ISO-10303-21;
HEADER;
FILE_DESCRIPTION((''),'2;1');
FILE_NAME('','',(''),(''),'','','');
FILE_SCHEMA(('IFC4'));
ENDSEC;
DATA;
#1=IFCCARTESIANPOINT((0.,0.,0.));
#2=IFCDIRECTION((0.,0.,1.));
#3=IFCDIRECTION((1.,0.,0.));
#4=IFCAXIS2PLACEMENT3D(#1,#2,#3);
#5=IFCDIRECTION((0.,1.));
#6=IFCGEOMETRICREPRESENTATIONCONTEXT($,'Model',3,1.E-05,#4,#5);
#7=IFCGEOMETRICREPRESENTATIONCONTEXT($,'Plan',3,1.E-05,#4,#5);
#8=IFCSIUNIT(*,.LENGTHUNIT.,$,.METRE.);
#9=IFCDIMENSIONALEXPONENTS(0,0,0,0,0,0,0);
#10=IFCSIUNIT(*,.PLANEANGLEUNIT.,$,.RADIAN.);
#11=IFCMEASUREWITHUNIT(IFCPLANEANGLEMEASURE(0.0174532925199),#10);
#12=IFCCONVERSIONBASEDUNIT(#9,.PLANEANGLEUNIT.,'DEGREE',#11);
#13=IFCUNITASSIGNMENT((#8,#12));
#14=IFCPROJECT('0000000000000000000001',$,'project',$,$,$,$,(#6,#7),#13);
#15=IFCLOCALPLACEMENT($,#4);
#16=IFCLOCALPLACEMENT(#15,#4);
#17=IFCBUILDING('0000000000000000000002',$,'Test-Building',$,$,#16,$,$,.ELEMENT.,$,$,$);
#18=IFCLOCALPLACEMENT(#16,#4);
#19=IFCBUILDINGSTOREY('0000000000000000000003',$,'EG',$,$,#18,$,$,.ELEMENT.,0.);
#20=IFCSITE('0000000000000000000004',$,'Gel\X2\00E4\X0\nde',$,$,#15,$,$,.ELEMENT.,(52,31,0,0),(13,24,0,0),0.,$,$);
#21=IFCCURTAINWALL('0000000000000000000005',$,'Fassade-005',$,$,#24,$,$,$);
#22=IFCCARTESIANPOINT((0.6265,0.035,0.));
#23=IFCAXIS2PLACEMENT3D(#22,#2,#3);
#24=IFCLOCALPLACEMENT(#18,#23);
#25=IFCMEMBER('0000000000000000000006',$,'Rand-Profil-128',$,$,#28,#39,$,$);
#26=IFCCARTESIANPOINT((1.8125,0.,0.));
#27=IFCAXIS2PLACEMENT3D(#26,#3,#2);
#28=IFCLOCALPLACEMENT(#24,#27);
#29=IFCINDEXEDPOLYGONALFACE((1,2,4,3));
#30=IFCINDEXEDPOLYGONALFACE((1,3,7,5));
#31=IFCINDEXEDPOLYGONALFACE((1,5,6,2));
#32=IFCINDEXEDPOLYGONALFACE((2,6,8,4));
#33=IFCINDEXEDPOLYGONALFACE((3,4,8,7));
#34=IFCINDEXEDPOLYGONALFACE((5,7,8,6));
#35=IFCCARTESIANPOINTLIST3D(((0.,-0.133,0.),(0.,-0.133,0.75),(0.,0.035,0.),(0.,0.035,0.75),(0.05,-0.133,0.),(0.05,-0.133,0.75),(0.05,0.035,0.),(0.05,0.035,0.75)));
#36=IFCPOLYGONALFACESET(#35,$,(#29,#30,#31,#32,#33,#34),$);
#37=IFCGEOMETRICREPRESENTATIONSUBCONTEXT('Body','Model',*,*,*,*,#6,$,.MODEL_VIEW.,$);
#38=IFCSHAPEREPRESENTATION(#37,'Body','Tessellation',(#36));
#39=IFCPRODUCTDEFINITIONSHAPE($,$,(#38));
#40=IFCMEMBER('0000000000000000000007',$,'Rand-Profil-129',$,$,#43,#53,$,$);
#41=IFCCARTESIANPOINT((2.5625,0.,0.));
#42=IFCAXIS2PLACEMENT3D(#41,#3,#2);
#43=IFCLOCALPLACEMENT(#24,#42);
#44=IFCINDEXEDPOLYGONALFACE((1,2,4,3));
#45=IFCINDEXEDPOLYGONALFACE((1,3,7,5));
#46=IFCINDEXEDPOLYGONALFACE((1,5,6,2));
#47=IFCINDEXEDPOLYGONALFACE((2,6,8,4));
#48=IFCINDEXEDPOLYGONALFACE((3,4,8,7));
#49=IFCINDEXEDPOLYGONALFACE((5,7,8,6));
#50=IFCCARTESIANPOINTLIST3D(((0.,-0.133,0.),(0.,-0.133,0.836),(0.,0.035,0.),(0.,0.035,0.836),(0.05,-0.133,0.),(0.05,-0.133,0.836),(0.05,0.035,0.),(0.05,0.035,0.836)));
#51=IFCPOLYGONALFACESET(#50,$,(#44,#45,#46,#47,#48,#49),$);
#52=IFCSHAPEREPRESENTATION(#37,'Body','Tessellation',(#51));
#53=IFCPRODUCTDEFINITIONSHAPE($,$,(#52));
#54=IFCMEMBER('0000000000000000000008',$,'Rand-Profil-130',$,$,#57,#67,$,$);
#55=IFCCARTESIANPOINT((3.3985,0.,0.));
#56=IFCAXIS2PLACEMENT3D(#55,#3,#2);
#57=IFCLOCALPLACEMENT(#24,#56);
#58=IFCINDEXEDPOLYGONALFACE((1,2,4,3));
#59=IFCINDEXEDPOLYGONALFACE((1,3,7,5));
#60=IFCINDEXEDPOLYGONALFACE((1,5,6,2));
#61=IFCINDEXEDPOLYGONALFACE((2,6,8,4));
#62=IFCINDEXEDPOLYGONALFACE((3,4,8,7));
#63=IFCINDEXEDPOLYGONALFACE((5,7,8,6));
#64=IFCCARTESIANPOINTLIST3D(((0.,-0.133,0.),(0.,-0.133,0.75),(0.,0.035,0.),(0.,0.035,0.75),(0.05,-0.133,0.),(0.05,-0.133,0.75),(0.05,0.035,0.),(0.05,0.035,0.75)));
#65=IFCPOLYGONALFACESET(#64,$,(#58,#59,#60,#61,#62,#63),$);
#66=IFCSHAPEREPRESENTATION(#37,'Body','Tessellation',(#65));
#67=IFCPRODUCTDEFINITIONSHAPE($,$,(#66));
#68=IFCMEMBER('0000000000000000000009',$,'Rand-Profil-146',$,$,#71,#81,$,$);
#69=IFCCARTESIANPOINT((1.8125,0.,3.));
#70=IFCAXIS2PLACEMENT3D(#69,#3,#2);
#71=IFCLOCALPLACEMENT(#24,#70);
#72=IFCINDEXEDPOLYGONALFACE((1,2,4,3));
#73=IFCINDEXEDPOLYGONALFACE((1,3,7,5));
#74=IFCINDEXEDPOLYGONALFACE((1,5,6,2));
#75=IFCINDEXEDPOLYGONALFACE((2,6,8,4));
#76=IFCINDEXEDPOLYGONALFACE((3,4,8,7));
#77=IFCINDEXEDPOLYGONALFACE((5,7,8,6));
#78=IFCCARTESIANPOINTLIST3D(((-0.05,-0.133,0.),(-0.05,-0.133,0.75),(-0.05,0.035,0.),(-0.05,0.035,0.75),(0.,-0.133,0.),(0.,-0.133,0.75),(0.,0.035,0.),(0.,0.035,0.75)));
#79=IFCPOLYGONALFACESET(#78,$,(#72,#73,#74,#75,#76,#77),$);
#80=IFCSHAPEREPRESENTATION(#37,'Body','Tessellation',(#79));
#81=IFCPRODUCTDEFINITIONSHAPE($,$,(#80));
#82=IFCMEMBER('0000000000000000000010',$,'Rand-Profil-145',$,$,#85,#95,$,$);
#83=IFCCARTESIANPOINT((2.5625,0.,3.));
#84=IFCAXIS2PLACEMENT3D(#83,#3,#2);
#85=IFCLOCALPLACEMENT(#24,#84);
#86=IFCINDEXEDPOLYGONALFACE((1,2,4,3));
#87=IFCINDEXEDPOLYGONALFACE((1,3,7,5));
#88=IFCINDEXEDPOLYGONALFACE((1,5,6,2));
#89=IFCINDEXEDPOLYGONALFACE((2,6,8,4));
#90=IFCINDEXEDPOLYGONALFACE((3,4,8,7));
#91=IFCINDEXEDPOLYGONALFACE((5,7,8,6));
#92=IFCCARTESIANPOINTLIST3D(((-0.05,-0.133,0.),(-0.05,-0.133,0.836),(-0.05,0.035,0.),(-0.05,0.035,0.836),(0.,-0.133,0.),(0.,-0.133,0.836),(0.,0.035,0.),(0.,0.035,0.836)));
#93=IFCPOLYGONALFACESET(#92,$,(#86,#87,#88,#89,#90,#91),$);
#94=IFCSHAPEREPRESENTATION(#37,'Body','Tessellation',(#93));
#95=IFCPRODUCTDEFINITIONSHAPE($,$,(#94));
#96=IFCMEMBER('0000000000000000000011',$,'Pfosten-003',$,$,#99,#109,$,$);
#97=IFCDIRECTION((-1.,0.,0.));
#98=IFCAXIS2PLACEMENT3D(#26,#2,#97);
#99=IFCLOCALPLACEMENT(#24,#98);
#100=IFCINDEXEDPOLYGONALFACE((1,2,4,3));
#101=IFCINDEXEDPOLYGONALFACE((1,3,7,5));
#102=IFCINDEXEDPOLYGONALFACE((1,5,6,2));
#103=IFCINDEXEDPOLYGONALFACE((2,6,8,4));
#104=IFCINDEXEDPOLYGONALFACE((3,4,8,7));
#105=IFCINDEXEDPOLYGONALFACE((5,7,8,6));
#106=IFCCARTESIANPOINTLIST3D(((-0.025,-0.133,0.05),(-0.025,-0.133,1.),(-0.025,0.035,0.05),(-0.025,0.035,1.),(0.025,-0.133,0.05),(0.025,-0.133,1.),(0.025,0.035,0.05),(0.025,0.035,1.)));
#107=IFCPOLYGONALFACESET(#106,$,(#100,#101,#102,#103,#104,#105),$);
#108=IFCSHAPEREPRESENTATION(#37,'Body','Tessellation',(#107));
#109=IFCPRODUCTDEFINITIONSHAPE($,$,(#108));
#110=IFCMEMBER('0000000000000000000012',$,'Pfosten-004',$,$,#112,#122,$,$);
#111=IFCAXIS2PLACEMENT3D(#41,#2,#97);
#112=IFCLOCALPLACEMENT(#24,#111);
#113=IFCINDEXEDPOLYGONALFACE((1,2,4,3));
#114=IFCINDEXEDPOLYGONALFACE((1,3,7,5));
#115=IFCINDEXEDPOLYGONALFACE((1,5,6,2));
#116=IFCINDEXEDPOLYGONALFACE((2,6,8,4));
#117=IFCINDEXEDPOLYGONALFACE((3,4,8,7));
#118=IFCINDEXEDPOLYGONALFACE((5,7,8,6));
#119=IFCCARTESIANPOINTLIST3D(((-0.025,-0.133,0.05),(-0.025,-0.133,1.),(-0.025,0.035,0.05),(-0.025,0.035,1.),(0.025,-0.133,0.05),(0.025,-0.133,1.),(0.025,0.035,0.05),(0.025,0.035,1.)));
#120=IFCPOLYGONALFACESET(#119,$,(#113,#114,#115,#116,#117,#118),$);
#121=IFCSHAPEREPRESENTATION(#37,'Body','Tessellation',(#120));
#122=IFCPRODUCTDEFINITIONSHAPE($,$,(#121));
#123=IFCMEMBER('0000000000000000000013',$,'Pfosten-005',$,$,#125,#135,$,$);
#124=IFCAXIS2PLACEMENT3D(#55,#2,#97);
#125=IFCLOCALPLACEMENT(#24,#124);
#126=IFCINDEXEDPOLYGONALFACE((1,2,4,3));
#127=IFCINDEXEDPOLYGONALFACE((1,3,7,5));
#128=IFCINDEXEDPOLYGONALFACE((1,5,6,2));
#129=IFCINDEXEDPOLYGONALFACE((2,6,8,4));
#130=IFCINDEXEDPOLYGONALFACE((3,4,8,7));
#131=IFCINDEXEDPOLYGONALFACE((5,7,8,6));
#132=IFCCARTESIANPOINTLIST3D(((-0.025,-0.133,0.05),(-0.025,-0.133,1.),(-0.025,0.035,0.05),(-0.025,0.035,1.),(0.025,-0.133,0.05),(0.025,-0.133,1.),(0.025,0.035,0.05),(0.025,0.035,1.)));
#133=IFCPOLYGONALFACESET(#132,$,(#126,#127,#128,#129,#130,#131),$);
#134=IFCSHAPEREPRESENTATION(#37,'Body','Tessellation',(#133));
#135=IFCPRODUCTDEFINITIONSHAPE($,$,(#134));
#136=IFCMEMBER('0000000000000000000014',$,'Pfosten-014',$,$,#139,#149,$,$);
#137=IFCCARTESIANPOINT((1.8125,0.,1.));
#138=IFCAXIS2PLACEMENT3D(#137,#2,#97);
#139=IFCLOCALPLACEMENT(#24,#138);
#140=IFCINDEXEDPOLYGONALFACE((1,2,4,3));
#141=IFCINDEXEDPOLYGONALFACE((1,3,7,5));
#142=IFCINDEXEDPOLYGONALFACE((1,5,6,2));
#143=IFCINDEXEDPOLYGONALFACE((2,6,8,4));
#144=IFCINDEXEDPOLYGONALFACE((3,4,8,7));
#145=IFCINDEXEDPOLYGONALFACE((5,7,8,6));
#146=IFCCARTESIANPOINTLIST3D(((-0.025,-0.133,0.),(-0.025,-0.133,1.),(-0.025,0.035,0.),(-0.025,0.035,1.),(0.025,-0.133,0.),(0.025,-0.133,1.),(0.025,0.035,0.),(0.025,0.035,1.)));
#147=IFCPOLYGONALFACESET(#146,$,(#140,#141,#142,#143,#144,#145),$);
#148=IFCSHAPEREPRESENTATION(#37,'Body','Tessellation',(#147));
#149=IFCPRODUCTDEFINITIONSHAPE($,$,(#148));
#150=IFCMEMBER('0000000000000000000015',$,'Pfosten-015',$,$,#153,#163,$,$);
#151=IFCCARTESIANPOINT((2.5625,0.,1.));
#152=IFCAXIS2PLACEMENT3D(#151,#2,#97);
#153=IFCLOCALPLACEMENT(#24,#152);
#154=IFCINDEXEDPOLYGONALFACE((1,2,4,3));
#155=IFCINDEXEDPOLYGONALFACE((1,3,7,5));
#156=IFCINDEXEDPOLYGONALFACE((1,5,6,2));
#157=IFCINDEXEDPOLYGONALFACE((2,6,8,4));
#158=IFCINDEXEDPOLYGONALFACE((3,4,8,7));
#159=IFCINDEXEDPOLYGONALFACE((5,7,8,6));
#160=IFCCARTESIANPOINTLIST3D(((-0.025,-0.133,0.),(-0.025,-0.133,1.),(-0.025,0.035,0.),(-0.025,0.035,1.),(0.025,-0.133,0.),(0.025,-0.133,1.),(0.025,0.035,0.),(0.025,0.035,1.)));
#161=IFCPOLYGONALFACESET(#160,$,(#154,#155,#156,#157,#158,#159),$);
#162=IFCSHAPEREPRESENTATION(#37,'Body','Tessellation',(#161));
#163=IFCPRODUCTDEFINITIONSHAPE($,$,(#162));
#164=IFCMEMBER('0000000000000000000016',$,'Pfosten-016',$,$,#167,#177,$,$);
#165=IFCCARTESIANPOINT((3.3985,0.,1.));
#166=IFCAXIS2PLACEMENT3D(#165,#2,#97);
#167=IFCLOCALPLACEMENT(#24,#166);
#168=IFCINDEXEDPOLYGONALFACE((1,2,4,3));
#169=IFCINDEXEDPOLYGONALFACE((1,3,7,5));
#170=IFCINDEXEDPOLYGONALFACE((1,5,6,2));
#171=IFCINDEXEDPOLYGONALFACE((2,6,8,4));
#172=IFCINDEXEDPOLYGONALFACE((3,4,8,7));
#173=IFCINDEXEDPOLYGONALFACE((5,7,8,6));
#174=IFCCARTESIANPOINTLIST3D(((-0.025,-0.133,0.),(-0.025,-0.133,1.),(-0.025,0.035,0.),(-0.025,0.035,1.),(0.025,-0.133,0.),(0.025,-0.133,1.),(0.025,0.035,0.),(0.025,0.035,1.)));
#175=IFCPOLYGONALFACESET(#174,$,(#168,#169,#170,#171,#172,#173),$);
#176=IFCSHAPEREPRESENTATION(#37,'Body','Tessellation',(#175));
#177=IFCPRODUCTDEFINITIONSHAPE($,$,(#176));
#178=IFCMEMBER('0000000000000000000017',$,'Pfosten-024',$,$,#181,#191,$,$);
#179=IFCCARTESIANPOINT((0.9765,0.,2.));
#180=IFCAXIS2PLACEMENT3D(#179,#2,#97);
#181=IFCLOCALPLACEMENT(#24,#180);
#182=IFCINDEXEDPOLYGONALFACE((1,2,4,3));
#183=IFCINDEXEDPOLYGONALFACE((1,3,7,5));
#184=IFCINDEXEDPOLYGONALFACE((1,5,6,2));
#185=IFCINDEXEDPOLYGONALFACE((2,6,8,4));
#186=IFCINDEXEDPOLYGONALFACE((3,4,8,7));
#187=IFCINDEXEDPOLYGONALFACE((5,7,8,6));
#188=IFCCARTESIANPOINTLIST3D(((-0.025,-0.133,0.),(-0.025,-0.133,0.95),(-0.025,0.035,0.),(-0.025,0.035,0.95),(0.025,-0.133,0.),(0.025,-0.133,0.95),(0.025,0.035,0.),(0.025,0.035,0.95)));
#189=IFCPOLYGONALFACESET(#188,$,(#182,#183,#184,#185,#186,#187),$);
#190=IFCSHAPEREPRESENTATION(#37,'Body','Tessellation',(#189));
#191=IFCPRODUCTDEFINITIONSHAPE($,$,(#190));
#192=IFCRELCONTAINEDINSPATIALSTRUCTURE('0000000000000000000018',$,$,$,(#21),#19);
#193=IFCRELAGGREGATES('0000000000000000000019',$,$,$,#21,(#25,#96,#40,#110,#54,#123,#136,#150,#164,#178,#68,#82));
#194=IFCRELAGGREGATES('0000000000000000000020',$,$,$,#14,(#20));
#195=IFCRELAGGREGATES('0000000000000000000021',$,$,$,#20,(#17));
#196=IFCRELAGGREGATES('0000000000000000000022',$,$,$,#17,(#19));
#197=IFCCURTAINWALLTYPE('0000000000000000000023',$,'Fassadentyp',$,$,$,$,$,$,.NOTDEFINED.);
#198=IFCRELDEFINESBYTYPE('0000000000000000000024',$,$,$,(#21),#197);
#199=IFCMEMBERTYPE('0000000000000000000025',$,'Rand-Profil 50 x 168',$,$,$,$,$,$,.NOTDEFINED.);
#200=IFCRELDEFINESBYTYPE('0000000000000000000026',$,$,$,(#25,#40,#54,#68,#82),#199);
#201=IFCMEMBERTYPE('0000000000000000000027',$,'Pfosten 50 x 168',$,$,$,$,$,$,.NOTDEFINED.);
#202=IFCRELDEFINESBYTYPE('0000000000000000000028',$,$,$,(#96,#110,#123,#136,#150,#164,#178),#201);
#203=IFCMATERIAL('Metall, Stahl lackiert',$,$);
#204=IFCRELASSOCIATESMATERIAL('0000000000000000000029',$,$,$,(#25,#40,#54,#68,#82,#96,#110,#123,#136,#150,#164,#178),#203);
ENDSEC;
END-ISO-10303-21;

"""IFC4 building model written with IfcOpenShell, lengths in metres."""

from ifc_helpers import new_model, entity, si_unit, converted_unit, direction, frame, origin_with_axes, place, context, subcontext, project, spatial, polyline, outline, extrude, material, type_object, element, aggregate, save


model = new_model("IFC4")

# Units and contexts
model_context = context("Model", 3, precision=1e-05, world=origin_with_axes(), true_north=direction((0.0, 1.0)))
plan_context = context("Plan", 3, precision=1e-05, world=origin_with_axes(), true_north=direction((0.0, 1.0)))
body_context = subcontext(model_context, "Body", "Model", "MODEL_VIEW")
ifc_project = project(units=[si_unit("LENGTHUNIT", "METRE"), converted_unit("PLANEANGLEUNIT", "DEGREE", entity("IfcPlaneAngleMeasure", 0.0174532925199), si_unit("PLANEANGLEUNIT", "RADIAN"), dimensions=[0, 0, 0, 0, 0, 0, 0])], contexts=[model_context, plan_context])

# Site, building, storey
site_placement = place(None, origin_with_axes())
site = spatial("IfcSite", under=ifc_project, at=site_placement, Name="Gelände", CompositionType="ELEMENT", RefLatitude=(52, 31, 0, 0), RefLongitude=(13, 24, 0, 0), RefElevation=0.0)
building_placement = place(site_placement, origin_with_axes())
building = spatial("IfcBuilding", under=site, at=building_placement, Name="Test-Building", CompositionType="ELEMENT")
storey_placement = place(building_placement, origin_with_axes())
storey = spatial("IfcBuildingStorey", under=building, at=storey_placement, Name="EG", CompositionType="ELEMENT", Elevation=0.0)

# Curtain wall, members
curtain_wall_type = type_object("IfcCurtainWallType", Name="Fassadentyp", PredefinedType="NOTDEFINED")
curtain_wall_placement = place(storey_placement, frame((0.6265, 0.035, 0.0), z_axis=(0.0, 0.0, 1.0), x_axis=(1.0, 0.0, 0.0)))
curtain_wall = element("IfcCurtainWall", 1, at=curtain_wall_placement, inside=storey, type_object=curtain_wall_type, Name="Fassade-005")
ifc_material_1 = material(Name="Metall, Stahl lackiert")
member_type_1 = type_object("IfcMemberType", Name="Rand-Profil 50 x 168", PredefinedType="NOTDEFINED")
member_1_placement = place(curtain_wall_placement, frame((1.8125, 0.0, 0.0), z_axis=(1.0, 0.0, 0.0), x_axis=(0.0, 0.0, 1.0)))
member_1 = element("IfcMember", 2, at=member_1_placement, type_object=member_type_1, material=ifc_material_1, Name="Rand-Profil-128", context=body_context, shape_type="SweptSolid", body=[
    extrude(outline(polyline([(-0.133, -0.05), (0.035, -0.05), (0.035, 0.0), (-0.133, 0.0), (-0.133, -0.05)])), frame((0.0, 0.0, 0.0), z_axis=(0.0, 0.0, 1.0), x_axis=(0.0, 1.0, 0.0)), (0.0, 0.0, 1.0), 0.75),
])
member_2_placement = place(curtain_wall_placement, frame((2.5625, 0.0, 0.0), z_axis=(1.0, 0.0, 0.0), x_axis=(0.0, 0.0, 1.0)))
member_2 = element("IfcMember", 3, at=member_2_placement, type_object=member_type_1, material=ifc_material_1, Name="Rand-Profil-129", context=body_context, shape_type="SweptSolid", body=[
    extrude(outline(polyline([(-0.133, -0.05), (0.035, -0.05), (0.035, 0.0), (-0.133, 0.0), (-0.133, -0.05)])), frame((0.0, 0.0, 0.0), z_axis=(0.0, 0.0, 1.0), x_axis=(0.0, 1.0, 0.0)), (0.0, 0.0, 1.0), 0.836),
])
member_3_placement = place(curtain_wall_placement, frame((3.3985, 0.0, 0.0), z_axis=(1.0, 0.0, 0.0), x_axis=(0.0, 0.0, 1.0)))
member_3 = element("IfcMember", 4, at=member_3_placement, type_object=member_type_1, material=ifc_material_1, Name="Rand-Profil-130", context=body_context, shape_type="SweptSolid", body=[
    extrude(outline(polyline([(-0.133, -0.05), (0.035, -0.05), (0.035, 0.0), (-0.133, 0.0), (-0.133, -0.05)])), frame((0.0, 0.0, 0.0), z_axis=(0.0, 0.0, 1.0), x_axis=(0.0, 1.0, 0.0)), (0.0, 0.0, 1.0), 0.75),
])
member_4_placement = place(curtain_wall_placement, frame((1.8125, 0.0, 3.0), z_axis=(1.0, 0.0, 0.0), x_axis=(0.0, 0.0, 1.0)))
member_4 = element("IfcMember", 5, at=member_4_placement, type_object=member_type_1, material=ifc_material_1, Name="Rand-Profil-146", context=body_context, shape_type="SweptSolid", body=[
    extrude(outline(polyline([(-0.133, 0.05), (-0.133, 0.0), (0.035, 0.0), (0.035, 0.05), (-0.133, 0.05)])), frame((0.0, 0.0, 0.0), z_axis=(0.0, 0.0, 1.0), x_axis=(0.0, 1.0, 0.0)), (0.0, 0.0, 1.0), 0.75),
])
member_5_placement = place(curtain_wall_placement, frame((2.5625, 0.0, 3.0), z_axis=(1.0, 0.0, 0.0), x_axis=(0.0, 0.0, 1.0)))
member_5 = element("IfcMember", 6, at=member_5_placement, type_object=member_type_1, material=ifc_material_1, Name="Rand-Profil-145", context=body_context, shape_type="SweptSolid", body=[
    extrude(outline(polyline([(-0.133, 0.05), (-0.133, 0.0), (0.035, 0.0), (0.035, 0.05), (-0.133, 0.05)])), frame((0.0, 0.0, 0.0), z_axis=(0.0, 0.0, 1.0), x_axis=(0.0, 1.0, 0.0)), (0.0, 0.0, 1.0), 0.836),
])
member_type_2 = type_object("IfcMemberType", Name="Pfosten 50 x 168", PredefinedType="NOTDEFINED")
member_6_placement = place(curtain_wall_placement, frame((1.8125, 0.0, 0.0), z_axis=(0.0, 0.0, 1.0), x_axis=(-1.0, 0.0, 0.0)))
member_6 = element("IfcMember", 7, at=member_6_placement, type_object=member_type_2, material=ifc_material_1, Name="Pfosten-003", context=body_context, shape_type="SweptSolid", body=[
    extrude(outline(polyline([(-0.025, 0.133), (-0.025, -0.035), (0.025, -0.035), (0.025, 0.133), (-0.025, 0.133)])), frame((0.0, 0.0, 0.05), z_axis=(0.0, 0.0, 1.0), x_axis=(-1.0, 0.0, 0.0)), (0.0, 0.0, 1.0), 0.95),
])
member_7_placement = place(curtain_wall_placement, frame((2.5625, 0.0, 0.0), z_axis=(0.0, 0.0, 1.0), x_axis=(-1.0, 0.0, 0.0)))
member_7 = element("IfcMember", 8, at=member_7_placement, type_object=member_type_2, material=ifc_material_1, Name="Pfosten-004", context=body_context, shape_type="SweptSolid", body=[
    extrude(outline(polyline([(-0.025, 0.133), (-0.025, -0.035), (0.025, -0.035), (0.025, 0.133), (-0.025, 0.133)])), frame((0.0, 0.0, 0.05), z_axis=(0.0, 0.0, 1.0), x_axis=(-1.0, 0.0, 0.0)), (0.0, 0.0, 1.0), 0.95),
])
member_8_placement = place(curtain_wall_placement, frame((3.3985, 0.0, 0.0), z_axis=(0.0, 0.0, 1.0), x_axis=(-1.0, 0.0, 0.0)))
member_8 = element("IfcMember", 9, at=member_8_placement, type_object=member_type_2, material=ifc_material_1, Name="Pfosten-005", context=body_context, shape_type="SweptSolid", body=[
    extrude(outline(polyline([(-0.025, 0.133), (-0.025, -0.035), (0.025, -0.035), (0.025, 0.133), (-0.025, 0.133)])), frame((0.0, 0.0, 0.05), z_axis=(0.0, 0.0, 1.0), x_axis=(-1.0, 0.0, 0.0)), (0.0, 0.0, 1.0), 0.95),
])
member_9_placement = place(curtain_wall_placement, frame((1.8125, 0.0, 1.0), z_axis=(0.0, 0.0, 1.0), x_axis=(-1.0, 0.0, 0.0)))
member_9 = element("IfcMember", 10, at=member_9_placement, type_object=member_type_2, material=ifc_material_1, Name="Pfosten-014", context=body_context, shape_type="SweptSolid", body=[
    extrude(outline(polyline([(-0.025, 0.133), (-0.025, -0.035), (0.025, -0.035), (0.025, 0.133), (-0.025, 0.133)])), frame((0.0, 0.0, 0.0), z_axis=(0.0, 0.0, 1.0), x_axis=(-1.0, 0.0, 0.0)), (0.0, 0.0, 1.0), 1.0),
])
member_10_placement = place(curtain_wall_placement, frame((2.5625, 0.0, 1.0), z_axis=(0.0, 0.0, 1.0), x_axis=(-1.0, 0.0, 0.0)))
member_10 = element("IfcMember", 11, at=member_10_placement, type_object=member_type_2, material=ifc_material_1, Name="Pfosten-015", context=body_context, shape_type="SweptSolid", body=[
    extrude(outline(polyline([(-0.025, 0.133), (-0.025, -0.035), (0.025, -0.035), (0.025, 0.133), (-0.025, 0.133)])), frame((0.0, 0.0, 0.0), z_axis=(0.0, 0.0, 1.0), x_axis=(-1.0, 0.0, 0.0)), (0.0, 0.0, 1.0), 1.0),
])
member_11_placement = place(curtain_wall_placement, frame((3.3985, 0.0, 1.0), z_axis=(0.0, 0.0, 1.0), x_axis=(-1.0, 0.0, 0.0)))
member_11 = element("IfcMember", 12, at=member_11_placement, type_object=member_type_2, material=ifc_material_1, Name="Pfosten-016", context=body_context, shape_type="SweptSolid", body=[
    extrude(outline(polyline([(-0.025, 0.133), (-0.025, -0.035), (0.025, -0.035), (0.025, 0.133), (-0.025, 0.133)])), frame((0.0, 0.0, 0.0), z_axis=(0.0, 0.0, 1.0), x_axis=(-1.0, 0.0, 0.0)), (0.0, 0.0, 1.0), 1.0),
])
member_12_placement = place(curtain_wall_placement, frame((0.9765, 0.0, 2.0), z_axis=(0.0, 0.0, 1.0), x_axis=(-1.0, 0.0, 0.0)))
member_12 = element("IfcMember", 13, at=member_12_placement, type_object=member_type_2, material=ifc_material_1, Name="Pfosten-024", context=body_context, shape_type="SweptSolid", body=[
    extrude(outline(polyline([(-0.025, 0.133), (-0.025, -0.035), (0.025, -0.035), (0.025, 0.133), (-0.025, 0.133)])), frame((0.0, 0.0, 0.0), z_axis=(0.0, 0.0, 1.0), x_axis=(-1.0, 0.0, 0.0)), (0.0, 0.0, 1.0), 0.95),
])
aggregate(curtain_wall, [member_1, member_6, member_2, member_7, member_3, member_8, member_9, member_10, member_11, member_12, member_4, member_5])

save(model, "model.ifc")
